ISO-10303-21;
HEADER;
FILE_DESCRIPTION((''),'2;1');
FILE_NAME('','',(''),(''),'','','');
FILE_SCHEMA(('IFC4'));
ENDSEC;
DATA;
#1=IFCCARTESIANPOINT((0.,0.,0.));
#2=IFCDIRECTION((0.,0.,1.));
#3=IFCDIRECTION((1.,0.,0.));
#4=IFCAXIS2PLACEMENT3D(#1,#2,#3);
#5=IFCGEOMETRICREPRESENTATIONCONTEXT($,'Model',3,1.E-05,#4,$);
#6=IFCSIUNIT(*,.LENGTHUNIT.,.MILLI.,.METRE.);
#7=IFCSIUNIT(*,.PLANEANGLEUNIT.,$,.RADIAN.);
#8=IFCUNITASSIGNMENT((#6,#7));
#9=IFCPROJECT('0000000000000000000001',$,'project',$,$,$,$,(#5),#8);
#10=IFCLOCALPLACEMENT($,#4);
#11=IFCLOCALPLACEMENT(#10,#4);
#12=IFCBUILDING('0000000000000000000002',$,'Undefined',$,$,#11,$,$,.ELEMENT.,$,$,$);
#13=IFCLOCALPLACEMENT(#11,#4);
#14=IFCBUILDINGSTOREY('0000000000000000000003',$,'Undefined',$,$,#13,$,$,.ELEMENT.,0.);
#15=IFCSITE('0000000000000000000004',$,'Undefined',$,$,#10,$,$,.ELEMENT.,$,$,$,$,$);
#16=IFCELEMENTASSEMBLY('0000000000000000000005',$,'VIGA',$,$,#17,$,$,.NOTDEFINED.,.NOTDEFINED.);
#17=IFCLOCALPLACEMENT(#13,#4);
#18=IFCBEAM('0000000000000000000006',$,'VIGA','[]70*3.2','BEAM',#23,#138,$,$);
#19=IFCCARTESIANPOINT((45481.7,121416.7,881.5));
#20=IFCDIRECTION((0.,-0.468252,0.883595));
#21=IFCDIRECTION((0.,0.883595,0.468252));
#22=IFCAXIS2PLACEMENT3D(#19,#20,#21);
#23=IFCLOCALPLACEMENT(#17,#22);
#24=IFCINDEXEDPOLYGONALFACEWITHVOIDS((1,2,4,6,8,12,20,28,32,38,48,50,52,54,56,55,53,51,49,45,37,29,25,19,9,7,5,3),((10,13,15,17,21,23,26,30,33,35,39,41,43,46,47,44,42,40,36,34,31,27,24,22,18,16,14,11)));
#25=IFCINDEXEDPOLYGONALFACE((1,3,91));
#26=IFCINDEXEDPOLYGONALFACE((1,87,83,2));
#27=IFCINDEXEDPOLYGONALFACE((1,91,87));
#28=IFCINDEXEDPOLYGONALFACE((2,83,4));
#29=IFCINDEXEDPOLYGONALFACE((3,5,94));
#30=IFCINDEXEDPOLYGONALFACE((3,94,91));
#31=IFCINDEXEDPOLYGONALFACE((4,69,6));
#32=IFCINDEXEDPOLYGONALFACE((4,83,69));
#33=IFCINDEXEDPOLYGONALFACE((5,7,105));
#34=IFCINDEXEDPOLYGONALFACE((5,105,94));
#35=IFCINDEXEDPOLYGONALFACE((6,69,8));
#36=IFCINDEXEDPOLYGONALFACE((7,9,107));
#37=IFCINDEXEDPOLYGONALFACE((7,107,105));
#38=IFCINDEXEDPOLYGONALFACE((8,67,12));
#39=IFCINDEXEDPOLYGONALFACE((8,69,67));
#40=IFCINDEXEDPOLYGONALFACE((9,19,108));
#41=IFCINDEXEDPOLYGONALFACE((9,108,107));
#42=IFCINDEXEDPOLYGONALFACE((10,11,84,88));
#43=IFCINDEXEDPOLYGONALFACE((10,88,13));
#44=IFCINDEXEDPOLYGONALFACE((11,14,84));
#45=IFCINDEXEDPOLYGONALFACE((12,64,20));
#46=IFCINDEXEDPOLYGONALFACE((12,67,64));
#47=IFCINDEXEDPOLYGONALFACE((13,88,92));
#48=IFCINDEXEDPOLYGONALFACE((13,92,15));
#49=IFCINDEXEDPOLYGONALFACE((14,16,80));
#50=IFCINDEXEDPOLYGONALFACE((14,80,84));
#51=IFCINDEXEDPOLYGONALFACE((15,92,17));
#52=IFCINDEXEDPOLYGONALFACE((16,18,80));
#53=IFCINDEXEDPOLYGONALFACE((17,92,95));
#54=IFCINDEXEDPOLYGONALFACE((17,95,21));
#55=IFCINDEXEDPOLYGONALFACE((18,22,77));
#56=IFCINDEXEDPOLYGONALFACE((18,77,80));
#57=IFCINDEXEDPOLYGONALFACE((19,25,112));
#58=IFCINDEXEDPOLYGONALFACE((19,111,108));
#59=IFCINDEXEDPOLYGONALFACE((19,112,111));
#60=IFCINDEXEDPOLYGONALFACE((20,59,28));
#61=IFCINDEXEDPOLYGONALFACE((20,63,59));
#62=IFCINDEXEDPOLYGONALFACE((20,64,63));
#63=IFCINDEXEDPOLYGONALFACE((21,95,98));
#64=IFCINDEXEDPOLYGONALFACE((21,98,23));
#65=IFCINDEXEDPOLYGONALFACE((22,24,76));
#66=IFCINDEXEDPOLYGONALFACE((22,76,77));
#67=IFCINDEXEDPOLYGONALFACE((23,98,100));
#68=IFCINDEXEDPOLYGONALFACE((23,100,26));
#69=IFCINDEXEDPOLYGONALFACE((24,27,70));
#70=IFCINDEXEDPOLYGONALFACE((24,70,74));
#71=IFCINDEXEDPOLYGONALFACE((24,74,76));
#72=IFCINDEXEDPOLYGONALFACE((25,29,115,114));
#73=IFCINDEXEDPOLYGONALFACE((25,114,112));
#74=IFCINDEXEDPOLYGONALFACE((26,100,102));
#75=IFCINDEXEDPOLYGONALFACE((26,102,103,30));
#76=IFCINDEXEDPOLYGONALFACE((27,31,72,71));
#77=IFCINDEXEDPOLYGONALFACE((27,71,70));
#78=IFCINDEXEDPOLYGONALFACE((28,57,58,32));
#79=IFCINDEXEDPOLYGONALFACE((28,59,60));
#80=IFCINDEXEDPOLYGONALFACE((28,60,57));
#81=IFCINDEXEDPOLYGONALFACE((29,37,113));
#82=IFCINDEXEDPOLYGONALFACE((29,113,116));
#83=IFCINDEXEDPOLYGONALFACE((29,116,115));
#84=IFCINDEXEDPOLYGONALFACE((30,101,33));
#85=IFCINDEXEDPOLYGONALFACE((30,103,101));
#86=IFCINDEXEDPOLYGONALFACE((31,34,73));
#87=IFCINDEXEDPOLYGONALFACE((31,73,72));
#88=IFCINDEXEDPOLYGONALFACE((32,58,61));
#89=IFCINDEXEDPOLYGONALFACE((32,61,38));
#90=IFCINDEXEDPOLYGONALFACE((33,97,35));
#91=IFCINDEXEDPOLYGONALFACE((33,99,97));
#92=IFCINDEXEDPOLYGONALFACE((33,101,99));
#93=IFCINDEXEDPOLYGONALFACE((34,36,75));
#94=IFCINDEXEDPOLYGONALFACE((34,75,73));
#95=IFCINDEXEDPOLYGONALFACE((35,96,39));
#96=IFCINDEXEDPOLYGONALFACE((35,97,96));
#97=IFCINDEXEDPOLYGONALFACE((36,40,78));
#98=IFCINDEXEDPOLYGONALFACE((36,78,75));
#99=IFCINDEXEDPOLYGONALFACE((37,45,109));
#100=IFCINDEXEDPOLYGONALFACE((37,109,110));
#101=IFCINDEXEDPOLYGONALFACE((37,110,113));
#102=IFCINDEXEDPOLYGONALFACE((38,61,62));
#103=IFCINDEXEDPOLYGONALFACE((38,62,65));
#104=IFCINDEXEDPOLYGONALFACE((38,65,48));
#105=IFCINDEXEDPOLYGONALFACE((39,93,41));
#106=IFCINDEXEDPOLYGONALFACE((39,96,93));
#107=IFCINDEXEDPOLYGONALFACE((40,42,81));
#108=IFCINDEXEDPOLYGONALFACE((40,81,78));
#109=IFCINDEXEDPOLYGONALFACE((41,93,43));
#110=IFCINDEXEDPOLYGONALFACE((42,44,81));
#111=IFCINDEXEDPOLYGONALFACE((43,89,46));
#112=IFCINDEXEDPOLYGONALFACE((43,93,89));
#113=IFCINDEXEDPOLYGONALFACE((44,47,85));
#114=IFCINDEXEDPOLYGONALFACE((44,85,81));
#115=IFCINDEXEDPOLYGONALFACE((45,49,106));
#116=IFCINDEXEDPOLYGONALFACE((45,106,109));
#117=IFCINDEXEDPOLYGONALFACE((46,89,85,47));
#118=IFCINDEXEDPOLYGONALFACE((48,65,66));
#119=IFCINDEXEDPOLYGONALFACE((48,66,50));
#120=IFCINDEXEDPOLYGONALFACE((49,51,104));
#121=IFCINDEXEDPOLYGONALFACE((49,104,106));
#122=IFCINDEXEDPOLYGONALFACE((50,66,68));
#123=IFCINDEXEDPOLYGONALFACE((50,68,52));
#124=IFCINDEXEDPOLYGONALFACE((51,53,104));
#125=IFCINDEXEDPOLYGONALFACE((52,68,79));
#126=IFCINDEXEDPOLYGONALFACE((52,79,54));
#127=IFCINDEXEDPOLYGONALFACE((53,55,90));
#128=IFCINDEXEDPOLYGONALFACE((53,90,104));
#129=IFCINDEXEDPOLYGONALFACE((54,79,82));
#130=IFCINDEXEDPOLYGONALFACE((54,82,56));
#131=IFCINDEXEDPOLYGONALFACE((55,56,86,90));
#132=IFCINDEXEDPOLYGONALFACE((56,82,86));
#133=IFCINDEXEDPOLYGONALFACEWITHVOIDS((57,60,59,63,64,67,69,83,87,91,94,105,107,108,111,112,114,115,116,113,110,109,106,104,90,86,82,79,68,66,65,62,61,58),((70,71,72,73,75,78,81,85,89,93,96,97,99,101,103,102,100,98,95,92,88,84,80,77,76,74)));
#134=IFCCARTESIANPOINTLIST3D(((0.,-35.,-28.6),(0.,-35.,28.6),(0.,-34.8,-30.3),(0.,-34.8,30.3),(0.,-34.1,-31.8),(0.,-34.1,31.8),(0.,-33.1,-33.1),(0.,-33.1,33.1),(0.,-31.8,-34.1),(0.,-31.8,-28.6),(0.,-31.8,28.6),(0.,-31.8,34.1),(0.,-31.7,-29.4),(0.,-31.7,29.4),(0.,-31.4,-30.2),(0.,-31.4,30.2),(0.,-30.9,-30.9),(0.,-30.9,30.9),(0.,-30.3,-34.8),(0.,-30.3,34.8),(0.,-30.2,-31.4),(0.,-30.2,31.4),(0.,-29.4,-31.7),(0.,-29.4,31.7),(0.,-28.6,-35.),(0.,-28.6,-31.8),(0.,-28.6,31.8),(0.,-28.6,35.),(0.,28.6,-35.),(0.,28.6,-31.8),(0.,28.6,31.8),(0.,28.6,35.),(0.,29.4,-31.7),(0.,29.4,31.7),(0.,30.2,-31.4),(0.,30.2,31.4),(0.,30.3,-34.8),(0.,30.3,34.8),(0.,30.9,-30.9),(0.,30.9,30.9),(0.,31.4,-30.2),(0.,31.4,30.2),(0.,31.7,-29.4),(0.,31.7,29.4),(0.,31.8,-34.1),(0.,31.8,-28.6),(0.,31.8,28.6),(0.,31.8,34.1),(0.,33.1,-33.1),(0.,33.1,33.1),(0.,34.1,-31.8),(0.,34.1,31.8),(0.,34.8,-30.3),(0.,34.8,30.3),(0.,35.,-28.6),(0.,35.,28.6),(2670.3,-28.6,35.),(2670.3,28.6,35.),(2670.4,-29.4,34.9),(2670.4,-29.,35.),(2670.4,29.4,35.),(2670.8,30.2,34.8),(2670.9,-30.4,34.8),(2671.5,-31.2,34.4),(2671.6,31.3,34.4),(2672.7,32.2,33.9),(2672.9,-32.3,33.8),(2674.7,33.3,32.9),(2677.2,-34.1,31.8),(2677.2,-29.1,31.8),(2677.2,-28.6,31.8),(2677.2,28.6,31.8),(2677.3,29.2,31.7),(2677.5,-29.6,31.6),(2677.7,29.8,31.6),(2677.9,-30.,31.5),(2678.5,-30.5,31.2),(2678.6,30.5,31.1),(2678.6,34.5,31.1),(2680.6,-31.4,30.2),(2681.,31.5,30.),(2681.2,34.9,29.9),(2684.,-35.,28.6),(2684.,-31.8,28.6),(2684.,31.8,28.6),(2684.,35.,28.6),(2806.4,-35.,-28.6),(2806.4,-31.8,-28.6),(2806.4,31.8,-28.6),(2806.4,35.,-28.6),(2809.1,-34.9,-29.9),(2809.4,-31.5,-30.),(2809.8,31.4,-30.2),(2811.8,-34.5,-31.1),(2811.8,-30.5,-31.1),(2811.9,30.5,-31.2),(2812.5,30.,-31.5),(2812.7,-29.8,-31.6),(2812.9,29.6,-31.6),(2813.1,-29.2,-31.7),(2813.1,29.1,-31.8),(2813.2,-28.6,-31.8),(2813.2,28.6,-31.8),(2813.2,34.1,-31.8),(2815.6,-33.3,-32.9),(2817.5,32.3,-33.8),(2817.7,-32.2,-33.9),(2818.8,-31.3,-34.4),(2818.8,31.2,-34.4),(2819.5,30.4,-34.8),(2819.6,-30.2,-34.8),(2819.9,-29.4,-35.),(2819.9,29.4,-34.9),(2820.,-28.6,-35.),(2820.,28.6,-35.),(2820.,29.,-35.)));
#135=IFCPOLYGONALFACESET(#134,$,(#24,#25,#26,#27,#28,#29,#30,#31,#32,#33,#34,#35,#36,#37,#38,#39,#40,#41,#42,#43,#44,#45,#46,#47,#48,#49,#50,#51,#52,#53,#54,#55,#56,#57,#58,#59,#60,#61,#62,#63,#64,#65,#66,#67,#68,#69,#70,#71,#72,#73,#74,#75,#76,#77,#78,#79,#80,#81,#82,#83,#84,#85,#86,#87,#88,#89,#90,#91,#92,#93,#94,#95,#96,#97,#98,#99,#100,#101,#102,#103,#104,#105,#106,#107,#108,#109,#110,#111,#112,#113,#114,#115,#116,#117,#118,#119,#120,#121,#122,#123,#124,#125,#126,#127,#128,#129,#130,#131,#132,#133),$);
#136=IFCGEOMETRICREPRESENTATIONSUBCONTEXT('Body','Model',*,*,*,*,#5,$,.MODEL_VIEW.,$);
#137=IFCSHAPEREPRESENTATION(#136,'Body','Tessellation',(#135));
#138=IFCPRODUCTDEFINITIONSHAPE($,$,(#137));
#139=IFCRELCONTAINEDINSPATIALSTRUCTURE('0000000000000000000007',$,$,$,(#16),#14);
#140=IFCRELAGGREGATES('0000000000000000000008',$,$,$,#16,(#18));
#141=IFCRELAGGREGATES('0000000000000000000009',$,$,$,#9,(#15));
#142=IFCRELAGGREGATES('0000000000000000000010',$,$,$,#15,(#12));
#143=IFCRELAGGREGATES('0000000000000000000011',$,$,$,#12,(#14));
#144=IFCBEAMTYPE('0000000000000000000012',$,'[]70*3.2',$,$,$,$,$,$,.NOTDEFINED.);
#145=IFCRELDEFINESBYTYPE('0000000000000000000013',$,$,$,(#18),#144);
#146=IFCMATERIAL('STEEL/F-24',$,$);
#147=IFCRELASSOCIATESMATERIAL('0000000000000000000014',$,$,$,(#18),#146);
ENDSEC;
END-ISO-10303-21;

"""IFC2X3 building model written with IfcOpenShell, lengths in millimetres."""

from ifc_helpers import new_model, si_unit, frame, origin_with_axes, origin_2d_with_axis, place, context, subcontext, project, spatial, hollow_rectangle, extrude, clip, halfspace, material, type_object, element, aggregate, save


model = new_model("IFC2X3")

# Units and contexts
model_context = context("Model", 3, precision=1e-05, world=origin_with_axes())
body_context = subcontext(model_context, "Body", "Model", "MODEL_VIEW")
ifc_project = project(units=[si_unit("LENGTHUNIT", "METRE", prefix="MILLI"), si_unit("PLANEANGLEUNIT", "RADIAN")], contexts=[model_context])

# Site, building, storey
site_placement = place(None, origin_with_axes())
site = spatial("IfcSite", under=ifc_project, at=site_placement, Name="Undefined", CompositionType="ELEMENT")
building_placement = place(site_placement, origin_with_axes())
building = spatial("IfcBuilding", under=site, at=building_placement, Name="Undefined", CompositionType="ELEMENT")
storey_placement = place(building_placement, origin_with_axes())
storey = spatial("IfcBuildingStorey", under=building, at=storey_placement, Name="Undefined", CompositionType="ELEMENT", Elevation=0.0)

# Element assembly, beam
assembly_1_placement = place(storey_placement, origin_with_axes())
assembly_1 = element("IfcElementAssembly", 1, at=assembly_1_placement, inside=storey, Name="VIGA", AssemblyPlace="NOTDEFINED", PredefinedType="NOTDEFINED")
ifc_material_1 = material(Name="STEEL/F-24")
beam_type_1 = type_object("IfcBeamType", Name="[]70*3.2", PredefinedType="NOTDEFINED")
beam_1_placement = place(assembly_1_placement, frame((45481.7, 121416.7, 881.5), z_axis=(0.0, -0.468252, 0.883595), x_axis=(0.0, 0.883595, 0.468252)))
beam_1 = element("IfcBeam", 2, at=beam_1_placement, type_object=beam_type_1, material=ifc_material_1, Name="VIGA", Description="[]70*3.2", ObjectType="BEAM", context=body_context, shape_type="Clipping", body=[
    clip(extrude(hollow_rectangle(XDim=70.0, YDim=70.0, WallThickness=3.2, InnerFilletRadius=3.2, OuterFilletRadius=6.4, at=origin_2d_with_axis()), frame((2850.0, 0.0, 0.0), z_axis=(-1.0, 0.0, 0.0), x_axis=(0.0, -1.0, 0.0)), (0.0, 0.0, 1.0), 2850.0), halfspace(frame((2745.2, 0.0, 0.0), z_axis=(-0.423531, 0.0, -0.905881), x_axis=(0.0, -1.0, 0.0)), True)),
])

aggregate(assembly_1, [beam_1])

save(model, "model.ifc")
